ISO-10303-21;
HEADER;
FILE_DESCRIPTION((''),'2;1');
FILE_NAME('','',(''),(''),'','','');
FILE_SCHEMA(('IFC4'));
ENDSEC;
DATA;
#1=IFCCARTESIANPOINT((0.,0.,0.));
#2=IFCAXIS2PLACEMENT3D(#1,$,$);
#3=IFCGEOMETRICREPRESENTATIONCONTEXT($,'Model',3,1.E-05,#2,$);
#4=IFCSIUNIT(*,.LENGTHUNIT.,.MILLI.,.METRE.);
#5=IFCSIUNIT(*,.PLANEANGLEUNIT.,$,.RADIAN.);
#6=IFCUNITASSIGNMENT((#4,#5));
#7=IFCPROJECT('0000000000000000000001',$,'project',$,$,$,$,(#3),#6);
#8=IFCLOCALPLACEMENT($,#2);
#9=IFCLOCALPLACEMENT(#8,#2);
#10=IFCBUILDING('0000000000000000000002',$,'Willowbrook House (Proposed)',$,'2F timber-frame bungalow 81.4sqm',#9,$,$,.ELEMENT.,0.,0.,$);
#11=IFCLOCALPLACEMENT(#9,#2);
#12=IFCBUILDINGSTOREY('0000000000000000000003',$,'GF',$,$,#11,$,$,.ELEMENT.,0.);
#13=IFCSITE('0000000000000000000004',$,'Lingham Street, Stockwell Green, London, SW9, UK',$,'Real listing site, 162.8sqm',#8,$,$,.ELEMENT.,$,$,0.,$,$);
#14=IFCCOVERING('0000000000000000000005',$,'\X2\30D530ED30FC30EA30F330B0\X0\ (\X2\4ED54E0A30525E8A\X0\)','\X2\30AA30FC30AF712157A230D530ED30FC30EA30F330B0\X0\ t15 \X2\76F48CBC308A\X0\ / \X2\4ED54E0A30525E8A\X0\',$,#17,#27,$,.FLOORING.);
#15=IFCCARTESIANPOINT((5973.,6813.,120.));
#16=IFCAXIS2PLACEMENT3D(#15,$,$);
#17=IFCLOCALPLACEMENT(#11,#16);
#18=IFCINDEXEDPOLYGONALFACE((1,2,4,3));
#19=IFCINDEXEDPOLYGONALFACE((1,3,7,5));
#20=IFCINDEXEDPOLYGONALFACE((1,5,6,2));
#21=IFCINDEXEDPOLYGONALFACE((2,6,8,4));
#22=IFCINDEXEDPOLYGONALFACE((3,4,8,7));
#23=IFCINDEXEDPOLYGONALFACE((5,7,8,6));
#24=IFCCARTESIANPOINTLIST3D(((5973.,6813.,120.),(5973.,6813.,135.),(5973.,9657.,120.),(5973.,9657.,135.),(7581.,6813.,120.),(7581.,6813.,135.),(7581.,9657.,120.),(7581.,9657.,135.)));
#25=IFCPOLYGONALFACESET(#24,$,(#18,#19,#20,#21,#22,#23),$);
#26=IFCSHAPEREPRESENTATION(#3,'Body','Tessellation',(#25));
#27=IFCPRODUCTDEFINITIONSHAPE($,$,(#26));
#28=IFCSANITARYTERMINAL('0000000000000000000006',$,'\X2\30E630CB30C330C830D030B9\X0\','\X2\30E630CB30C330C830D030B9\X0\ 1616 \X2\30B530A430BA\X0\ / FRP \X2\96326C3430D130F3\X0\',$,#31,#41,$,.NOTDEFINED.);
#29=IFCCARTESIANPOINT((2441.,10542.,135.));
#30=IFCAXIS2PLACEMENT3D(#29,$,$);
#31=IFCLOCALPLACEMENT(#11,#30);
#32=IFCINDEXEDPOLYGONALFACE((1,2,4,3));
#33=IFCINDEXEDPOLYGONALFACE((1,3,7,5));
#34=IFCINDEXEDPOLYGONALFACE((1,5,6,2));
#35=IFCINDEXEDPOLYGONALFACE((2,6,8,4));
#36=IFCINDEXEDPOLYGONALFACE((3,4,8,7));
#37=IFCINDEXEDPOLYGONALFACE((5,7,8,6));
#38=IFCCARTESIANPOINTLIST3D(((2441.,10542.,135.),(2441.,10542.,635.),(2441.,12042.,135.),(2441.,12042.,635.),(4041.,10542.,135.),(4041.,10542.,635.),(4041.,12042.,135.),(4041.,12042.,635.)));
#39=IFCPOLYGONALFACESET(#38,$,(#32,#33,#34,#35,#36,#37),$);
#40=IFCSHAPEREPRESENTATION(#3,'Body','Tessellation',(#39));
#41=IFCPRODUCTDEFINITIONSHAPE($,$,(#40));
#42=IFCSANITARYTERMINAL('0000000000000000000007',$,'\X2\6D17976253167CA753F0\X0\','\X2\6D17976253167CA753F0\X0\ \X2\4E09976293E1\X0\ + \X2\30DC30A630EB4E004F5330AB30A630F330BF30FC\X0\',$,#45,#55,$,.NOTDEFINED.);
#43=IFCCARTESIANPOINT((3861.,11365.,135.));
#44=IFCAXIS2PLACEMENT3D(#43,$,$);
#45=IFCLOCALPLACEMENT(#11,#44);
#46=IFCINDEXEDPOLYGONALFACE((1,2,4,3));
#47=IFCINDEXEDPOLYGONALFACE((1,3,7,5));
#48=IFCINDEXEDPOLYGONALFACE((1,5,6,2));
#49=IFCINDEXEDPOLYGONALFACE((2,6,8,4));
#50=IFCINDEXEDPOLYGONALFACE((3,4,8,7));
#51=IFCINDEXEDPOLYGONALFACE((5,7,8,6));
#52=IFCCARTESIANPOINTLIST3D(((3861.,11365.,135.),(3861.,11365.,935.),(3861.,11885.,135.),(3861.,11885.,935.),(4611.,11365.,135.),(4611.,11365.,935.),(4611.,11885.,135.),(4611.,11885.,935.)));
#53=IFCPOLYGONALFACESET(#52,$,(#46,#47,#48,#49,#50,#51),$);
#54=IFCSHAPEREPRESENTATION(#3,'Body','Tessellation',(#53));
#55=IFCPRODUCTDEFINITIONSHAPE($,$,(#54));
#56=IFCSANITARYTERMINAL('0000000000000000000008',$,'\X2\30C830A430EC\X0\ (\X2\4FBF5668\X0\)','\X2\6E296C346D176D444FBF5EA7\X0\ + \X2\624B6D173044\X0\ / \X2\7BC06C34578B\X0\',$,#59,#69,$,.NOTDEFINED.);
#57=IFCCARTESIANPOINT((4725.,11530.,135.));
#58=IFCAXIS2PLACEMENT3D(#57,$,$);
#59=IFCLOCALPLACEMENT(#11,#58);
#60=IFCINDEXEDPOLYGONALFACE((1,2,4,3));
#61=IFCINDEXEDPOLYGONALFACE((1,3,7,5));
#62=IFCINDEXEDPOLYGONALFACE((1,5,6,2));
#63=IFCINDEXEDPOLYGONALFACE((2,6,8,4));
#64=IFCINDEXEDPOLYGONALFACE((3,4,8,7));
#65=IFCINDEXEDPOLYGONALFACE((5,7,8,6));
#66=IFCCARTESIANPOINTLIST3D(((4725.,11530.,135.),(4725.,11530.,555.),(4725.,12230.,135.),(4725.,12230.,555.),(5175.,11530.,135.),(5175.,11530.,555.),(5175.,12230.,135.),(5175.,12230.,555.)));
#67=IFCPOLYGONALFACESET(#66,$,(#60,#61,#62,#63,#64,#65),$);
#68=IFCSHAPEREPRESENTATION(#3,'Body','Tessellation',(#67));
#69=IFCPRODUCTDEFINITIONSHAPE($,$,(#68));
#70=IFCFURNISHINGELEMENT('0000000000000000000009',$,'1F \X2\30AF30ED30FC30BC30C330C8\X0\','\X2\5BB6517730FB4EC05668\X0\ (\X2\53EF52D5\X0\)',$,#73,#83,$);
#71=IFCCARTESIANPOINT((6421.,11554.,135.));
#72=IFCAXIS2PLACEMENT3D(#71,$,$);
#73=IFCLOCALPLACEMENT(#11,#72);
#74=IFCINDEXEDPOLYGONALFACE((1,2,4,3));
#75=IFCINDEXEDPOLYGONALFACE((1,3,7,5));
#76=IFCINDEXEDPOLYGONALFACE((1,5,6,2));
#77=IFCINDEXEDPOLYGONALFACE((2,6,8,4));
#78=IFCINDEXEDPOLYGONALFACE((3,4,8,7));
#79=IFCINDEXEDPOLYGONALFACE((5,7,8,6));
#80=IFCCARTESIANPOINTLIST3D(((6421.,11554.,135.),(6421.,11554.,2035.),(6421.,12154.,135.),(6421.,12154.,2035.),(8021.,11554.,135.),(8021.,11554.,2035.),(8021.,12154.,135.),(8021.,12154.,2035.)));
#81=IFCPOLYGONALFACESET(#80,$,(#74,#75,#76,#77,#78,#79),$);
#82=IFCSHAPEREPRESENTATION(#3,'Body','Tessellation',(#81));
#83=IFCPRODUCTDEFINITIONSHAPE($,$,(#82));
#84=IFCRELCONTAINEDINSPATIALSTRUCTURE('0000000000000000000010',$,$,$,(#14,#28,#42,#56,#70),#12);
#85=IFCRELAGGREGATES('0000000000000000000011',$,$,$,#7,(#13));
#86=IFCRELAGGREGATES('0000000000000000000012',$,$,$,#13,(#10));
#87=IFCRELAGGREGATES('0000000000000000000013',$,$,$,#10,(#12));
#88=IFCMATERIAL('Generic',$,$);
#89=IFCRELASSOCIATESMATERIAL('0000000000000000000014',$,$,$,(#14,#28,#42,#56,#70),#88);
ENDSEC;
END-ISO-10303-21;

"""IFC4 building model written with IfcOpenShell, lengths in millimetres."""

from ifc_helpers import new_model, si_unit, frame, frame_2d, origin, place, context, project, spatial, rectangle, extrude, material, element, save


model = new_model("IFC4")

# Units and contexts
model_context = context("Model", 3, precision=1e-05, world=origin())
ifc_project = project(units=[si_unit("LENGTHUNIT", "METRE", prefix="MILLI"), si_unit("PLANEANGLEUNIT", "RADIAN")], contexts=[model_context])

# Site, building, storey
site_placement = place(None, origin())
site = spatial("IfcSite", under=ifc_project, at=site_placement, Name="Lingham Street, Stockwell Green, London, SW9, UK", ObjectType="Real listing site, 162.8sqm", CompositionType="ELEMENT", RefElevation=0.0)
building_placement = place(site_placement, origin())
building = spatial("IfcBuilding", under=site, at=building_placement, Name="Willowbrook House (Proposed)", ObjectType="2F timber-frame bungalow 81.4sqm", CompositionType="ELEMENT", ElevationOfRefHeight=0.0, ElevationOfTerrain=0.0)
storey_placement = place(building_placement, origin())
storey = spatial("IfcBuildingStorey", under=building, at=storey_placement, Name="GF", CompositionType="ELEMENT", Elevation=0.0)

# Covering
ifc_material_1 = material(Name="Generic")
covering_1_placement = place(storey_placement, frame((5973.0, 6813.0, 120.0)))
element("IfcCovering", 1, at=covering_1_placement, inside=storey, material=ifc_material_1, Name="フローリング (仕上げ床)", Description="オーク無垢フローリング t15 直貼り / 仕上げ床", PredefinedType="FLOORING", context=model_context, shape_type="SweptSolid", body=[
    extrude(rectangle(XDim=1608.0, YDim=2844.0, at=frame_2d((804.0, 1422.0))), frame((5973.0, 6813.0, 120.0)), (0.0, 0.0, 1.0), 15.0),
])

# Sanitary terminals
sanitary_terminal_1_placement = place(storey_placement, frame((2441.0, 10542.0, 135.0)))
element("IfcSanitaryTerminal", 2, at=sanitary_terminal_1_placement, inside=storey, material=ifc_material_1, Name="ユニットバス", Description="ユニットバス 1616 サイズ / FRP 防水パン", PredefinedType="NOTDEFINED", context=model_context, shape_type="SweptSolid", body=[
    extrude(rectangle(XDim=1600.0, YDim=1500.0, at=frame_2d((800.0, 750.0))), frame((2441.0, 10542.0, 135.0)), (0.0, 0.0, 1.0), 500.0),
])
sanitary_terminal_2_placement = place(storey_placement, frame((3861.0, 11365.0, 135.0)))
element("IfcSanitaryTerminal", 3, at=sanitary_terminal_2_placement, inside=storey, material=ifc_material_1, Name="洗面化粧台", Description="洗面化粧台 三面鏡 + ボウル一体カウンター", PredefinedType="NOTDEFINED", context=model_context, shape_type="SweptSolid", body=[
    extrude(rectangle(XDim=750.0, YDim=520.0, at=frame_2d((375.0, 260.0))), frame((3861.0, 11365.0, 135.0)), (0.0, 0.0, 1.0), 800.0),
])
sanitary_terminal_3_placement = place(storey_placement, frame((4725.0, 11530.0, 135.0)))
element("IfcSanitaryTerminal", 4, at=sanitary_terminal_3_placement, inside=storey, material=ifc_material_1, Name="トイレ (便器)", Description="温水洗浄便座 + 手洗い / 節水型", PredefinedType="NOTDEFINED", context=model_context, shape_type="SweptSolid", body=[
    extrude(rectangle(XDim=450.0, YDim=700.0, at=frame_2d((225.0, 350.0))), frame((4725.0, 11530.0, 135.0)), (0.0, 0.0, 1.0), 420.0),
])

# Furnishing element
furnishing_placement = place(storey_placement, frame((6421.0, 11554.0, 135.0)))
element("IfcFurnishingElement", 5, at=furnishing_placement, inside=storey, material=ifc_material_1, Name="1F クローゼット", Description="家具・什器 (可動)", context=model_context, shape_type="SweptSolid", body=[
    extrude(rectangle(XDim=1600.0, YDim=600.0, at=frame_2d((800.0, 300.0))), frame((6421.0, 11554.0, 135.0)), (0.0, 0.0, 1.0), 1900.0),
])

save(model, "model.ifc")
